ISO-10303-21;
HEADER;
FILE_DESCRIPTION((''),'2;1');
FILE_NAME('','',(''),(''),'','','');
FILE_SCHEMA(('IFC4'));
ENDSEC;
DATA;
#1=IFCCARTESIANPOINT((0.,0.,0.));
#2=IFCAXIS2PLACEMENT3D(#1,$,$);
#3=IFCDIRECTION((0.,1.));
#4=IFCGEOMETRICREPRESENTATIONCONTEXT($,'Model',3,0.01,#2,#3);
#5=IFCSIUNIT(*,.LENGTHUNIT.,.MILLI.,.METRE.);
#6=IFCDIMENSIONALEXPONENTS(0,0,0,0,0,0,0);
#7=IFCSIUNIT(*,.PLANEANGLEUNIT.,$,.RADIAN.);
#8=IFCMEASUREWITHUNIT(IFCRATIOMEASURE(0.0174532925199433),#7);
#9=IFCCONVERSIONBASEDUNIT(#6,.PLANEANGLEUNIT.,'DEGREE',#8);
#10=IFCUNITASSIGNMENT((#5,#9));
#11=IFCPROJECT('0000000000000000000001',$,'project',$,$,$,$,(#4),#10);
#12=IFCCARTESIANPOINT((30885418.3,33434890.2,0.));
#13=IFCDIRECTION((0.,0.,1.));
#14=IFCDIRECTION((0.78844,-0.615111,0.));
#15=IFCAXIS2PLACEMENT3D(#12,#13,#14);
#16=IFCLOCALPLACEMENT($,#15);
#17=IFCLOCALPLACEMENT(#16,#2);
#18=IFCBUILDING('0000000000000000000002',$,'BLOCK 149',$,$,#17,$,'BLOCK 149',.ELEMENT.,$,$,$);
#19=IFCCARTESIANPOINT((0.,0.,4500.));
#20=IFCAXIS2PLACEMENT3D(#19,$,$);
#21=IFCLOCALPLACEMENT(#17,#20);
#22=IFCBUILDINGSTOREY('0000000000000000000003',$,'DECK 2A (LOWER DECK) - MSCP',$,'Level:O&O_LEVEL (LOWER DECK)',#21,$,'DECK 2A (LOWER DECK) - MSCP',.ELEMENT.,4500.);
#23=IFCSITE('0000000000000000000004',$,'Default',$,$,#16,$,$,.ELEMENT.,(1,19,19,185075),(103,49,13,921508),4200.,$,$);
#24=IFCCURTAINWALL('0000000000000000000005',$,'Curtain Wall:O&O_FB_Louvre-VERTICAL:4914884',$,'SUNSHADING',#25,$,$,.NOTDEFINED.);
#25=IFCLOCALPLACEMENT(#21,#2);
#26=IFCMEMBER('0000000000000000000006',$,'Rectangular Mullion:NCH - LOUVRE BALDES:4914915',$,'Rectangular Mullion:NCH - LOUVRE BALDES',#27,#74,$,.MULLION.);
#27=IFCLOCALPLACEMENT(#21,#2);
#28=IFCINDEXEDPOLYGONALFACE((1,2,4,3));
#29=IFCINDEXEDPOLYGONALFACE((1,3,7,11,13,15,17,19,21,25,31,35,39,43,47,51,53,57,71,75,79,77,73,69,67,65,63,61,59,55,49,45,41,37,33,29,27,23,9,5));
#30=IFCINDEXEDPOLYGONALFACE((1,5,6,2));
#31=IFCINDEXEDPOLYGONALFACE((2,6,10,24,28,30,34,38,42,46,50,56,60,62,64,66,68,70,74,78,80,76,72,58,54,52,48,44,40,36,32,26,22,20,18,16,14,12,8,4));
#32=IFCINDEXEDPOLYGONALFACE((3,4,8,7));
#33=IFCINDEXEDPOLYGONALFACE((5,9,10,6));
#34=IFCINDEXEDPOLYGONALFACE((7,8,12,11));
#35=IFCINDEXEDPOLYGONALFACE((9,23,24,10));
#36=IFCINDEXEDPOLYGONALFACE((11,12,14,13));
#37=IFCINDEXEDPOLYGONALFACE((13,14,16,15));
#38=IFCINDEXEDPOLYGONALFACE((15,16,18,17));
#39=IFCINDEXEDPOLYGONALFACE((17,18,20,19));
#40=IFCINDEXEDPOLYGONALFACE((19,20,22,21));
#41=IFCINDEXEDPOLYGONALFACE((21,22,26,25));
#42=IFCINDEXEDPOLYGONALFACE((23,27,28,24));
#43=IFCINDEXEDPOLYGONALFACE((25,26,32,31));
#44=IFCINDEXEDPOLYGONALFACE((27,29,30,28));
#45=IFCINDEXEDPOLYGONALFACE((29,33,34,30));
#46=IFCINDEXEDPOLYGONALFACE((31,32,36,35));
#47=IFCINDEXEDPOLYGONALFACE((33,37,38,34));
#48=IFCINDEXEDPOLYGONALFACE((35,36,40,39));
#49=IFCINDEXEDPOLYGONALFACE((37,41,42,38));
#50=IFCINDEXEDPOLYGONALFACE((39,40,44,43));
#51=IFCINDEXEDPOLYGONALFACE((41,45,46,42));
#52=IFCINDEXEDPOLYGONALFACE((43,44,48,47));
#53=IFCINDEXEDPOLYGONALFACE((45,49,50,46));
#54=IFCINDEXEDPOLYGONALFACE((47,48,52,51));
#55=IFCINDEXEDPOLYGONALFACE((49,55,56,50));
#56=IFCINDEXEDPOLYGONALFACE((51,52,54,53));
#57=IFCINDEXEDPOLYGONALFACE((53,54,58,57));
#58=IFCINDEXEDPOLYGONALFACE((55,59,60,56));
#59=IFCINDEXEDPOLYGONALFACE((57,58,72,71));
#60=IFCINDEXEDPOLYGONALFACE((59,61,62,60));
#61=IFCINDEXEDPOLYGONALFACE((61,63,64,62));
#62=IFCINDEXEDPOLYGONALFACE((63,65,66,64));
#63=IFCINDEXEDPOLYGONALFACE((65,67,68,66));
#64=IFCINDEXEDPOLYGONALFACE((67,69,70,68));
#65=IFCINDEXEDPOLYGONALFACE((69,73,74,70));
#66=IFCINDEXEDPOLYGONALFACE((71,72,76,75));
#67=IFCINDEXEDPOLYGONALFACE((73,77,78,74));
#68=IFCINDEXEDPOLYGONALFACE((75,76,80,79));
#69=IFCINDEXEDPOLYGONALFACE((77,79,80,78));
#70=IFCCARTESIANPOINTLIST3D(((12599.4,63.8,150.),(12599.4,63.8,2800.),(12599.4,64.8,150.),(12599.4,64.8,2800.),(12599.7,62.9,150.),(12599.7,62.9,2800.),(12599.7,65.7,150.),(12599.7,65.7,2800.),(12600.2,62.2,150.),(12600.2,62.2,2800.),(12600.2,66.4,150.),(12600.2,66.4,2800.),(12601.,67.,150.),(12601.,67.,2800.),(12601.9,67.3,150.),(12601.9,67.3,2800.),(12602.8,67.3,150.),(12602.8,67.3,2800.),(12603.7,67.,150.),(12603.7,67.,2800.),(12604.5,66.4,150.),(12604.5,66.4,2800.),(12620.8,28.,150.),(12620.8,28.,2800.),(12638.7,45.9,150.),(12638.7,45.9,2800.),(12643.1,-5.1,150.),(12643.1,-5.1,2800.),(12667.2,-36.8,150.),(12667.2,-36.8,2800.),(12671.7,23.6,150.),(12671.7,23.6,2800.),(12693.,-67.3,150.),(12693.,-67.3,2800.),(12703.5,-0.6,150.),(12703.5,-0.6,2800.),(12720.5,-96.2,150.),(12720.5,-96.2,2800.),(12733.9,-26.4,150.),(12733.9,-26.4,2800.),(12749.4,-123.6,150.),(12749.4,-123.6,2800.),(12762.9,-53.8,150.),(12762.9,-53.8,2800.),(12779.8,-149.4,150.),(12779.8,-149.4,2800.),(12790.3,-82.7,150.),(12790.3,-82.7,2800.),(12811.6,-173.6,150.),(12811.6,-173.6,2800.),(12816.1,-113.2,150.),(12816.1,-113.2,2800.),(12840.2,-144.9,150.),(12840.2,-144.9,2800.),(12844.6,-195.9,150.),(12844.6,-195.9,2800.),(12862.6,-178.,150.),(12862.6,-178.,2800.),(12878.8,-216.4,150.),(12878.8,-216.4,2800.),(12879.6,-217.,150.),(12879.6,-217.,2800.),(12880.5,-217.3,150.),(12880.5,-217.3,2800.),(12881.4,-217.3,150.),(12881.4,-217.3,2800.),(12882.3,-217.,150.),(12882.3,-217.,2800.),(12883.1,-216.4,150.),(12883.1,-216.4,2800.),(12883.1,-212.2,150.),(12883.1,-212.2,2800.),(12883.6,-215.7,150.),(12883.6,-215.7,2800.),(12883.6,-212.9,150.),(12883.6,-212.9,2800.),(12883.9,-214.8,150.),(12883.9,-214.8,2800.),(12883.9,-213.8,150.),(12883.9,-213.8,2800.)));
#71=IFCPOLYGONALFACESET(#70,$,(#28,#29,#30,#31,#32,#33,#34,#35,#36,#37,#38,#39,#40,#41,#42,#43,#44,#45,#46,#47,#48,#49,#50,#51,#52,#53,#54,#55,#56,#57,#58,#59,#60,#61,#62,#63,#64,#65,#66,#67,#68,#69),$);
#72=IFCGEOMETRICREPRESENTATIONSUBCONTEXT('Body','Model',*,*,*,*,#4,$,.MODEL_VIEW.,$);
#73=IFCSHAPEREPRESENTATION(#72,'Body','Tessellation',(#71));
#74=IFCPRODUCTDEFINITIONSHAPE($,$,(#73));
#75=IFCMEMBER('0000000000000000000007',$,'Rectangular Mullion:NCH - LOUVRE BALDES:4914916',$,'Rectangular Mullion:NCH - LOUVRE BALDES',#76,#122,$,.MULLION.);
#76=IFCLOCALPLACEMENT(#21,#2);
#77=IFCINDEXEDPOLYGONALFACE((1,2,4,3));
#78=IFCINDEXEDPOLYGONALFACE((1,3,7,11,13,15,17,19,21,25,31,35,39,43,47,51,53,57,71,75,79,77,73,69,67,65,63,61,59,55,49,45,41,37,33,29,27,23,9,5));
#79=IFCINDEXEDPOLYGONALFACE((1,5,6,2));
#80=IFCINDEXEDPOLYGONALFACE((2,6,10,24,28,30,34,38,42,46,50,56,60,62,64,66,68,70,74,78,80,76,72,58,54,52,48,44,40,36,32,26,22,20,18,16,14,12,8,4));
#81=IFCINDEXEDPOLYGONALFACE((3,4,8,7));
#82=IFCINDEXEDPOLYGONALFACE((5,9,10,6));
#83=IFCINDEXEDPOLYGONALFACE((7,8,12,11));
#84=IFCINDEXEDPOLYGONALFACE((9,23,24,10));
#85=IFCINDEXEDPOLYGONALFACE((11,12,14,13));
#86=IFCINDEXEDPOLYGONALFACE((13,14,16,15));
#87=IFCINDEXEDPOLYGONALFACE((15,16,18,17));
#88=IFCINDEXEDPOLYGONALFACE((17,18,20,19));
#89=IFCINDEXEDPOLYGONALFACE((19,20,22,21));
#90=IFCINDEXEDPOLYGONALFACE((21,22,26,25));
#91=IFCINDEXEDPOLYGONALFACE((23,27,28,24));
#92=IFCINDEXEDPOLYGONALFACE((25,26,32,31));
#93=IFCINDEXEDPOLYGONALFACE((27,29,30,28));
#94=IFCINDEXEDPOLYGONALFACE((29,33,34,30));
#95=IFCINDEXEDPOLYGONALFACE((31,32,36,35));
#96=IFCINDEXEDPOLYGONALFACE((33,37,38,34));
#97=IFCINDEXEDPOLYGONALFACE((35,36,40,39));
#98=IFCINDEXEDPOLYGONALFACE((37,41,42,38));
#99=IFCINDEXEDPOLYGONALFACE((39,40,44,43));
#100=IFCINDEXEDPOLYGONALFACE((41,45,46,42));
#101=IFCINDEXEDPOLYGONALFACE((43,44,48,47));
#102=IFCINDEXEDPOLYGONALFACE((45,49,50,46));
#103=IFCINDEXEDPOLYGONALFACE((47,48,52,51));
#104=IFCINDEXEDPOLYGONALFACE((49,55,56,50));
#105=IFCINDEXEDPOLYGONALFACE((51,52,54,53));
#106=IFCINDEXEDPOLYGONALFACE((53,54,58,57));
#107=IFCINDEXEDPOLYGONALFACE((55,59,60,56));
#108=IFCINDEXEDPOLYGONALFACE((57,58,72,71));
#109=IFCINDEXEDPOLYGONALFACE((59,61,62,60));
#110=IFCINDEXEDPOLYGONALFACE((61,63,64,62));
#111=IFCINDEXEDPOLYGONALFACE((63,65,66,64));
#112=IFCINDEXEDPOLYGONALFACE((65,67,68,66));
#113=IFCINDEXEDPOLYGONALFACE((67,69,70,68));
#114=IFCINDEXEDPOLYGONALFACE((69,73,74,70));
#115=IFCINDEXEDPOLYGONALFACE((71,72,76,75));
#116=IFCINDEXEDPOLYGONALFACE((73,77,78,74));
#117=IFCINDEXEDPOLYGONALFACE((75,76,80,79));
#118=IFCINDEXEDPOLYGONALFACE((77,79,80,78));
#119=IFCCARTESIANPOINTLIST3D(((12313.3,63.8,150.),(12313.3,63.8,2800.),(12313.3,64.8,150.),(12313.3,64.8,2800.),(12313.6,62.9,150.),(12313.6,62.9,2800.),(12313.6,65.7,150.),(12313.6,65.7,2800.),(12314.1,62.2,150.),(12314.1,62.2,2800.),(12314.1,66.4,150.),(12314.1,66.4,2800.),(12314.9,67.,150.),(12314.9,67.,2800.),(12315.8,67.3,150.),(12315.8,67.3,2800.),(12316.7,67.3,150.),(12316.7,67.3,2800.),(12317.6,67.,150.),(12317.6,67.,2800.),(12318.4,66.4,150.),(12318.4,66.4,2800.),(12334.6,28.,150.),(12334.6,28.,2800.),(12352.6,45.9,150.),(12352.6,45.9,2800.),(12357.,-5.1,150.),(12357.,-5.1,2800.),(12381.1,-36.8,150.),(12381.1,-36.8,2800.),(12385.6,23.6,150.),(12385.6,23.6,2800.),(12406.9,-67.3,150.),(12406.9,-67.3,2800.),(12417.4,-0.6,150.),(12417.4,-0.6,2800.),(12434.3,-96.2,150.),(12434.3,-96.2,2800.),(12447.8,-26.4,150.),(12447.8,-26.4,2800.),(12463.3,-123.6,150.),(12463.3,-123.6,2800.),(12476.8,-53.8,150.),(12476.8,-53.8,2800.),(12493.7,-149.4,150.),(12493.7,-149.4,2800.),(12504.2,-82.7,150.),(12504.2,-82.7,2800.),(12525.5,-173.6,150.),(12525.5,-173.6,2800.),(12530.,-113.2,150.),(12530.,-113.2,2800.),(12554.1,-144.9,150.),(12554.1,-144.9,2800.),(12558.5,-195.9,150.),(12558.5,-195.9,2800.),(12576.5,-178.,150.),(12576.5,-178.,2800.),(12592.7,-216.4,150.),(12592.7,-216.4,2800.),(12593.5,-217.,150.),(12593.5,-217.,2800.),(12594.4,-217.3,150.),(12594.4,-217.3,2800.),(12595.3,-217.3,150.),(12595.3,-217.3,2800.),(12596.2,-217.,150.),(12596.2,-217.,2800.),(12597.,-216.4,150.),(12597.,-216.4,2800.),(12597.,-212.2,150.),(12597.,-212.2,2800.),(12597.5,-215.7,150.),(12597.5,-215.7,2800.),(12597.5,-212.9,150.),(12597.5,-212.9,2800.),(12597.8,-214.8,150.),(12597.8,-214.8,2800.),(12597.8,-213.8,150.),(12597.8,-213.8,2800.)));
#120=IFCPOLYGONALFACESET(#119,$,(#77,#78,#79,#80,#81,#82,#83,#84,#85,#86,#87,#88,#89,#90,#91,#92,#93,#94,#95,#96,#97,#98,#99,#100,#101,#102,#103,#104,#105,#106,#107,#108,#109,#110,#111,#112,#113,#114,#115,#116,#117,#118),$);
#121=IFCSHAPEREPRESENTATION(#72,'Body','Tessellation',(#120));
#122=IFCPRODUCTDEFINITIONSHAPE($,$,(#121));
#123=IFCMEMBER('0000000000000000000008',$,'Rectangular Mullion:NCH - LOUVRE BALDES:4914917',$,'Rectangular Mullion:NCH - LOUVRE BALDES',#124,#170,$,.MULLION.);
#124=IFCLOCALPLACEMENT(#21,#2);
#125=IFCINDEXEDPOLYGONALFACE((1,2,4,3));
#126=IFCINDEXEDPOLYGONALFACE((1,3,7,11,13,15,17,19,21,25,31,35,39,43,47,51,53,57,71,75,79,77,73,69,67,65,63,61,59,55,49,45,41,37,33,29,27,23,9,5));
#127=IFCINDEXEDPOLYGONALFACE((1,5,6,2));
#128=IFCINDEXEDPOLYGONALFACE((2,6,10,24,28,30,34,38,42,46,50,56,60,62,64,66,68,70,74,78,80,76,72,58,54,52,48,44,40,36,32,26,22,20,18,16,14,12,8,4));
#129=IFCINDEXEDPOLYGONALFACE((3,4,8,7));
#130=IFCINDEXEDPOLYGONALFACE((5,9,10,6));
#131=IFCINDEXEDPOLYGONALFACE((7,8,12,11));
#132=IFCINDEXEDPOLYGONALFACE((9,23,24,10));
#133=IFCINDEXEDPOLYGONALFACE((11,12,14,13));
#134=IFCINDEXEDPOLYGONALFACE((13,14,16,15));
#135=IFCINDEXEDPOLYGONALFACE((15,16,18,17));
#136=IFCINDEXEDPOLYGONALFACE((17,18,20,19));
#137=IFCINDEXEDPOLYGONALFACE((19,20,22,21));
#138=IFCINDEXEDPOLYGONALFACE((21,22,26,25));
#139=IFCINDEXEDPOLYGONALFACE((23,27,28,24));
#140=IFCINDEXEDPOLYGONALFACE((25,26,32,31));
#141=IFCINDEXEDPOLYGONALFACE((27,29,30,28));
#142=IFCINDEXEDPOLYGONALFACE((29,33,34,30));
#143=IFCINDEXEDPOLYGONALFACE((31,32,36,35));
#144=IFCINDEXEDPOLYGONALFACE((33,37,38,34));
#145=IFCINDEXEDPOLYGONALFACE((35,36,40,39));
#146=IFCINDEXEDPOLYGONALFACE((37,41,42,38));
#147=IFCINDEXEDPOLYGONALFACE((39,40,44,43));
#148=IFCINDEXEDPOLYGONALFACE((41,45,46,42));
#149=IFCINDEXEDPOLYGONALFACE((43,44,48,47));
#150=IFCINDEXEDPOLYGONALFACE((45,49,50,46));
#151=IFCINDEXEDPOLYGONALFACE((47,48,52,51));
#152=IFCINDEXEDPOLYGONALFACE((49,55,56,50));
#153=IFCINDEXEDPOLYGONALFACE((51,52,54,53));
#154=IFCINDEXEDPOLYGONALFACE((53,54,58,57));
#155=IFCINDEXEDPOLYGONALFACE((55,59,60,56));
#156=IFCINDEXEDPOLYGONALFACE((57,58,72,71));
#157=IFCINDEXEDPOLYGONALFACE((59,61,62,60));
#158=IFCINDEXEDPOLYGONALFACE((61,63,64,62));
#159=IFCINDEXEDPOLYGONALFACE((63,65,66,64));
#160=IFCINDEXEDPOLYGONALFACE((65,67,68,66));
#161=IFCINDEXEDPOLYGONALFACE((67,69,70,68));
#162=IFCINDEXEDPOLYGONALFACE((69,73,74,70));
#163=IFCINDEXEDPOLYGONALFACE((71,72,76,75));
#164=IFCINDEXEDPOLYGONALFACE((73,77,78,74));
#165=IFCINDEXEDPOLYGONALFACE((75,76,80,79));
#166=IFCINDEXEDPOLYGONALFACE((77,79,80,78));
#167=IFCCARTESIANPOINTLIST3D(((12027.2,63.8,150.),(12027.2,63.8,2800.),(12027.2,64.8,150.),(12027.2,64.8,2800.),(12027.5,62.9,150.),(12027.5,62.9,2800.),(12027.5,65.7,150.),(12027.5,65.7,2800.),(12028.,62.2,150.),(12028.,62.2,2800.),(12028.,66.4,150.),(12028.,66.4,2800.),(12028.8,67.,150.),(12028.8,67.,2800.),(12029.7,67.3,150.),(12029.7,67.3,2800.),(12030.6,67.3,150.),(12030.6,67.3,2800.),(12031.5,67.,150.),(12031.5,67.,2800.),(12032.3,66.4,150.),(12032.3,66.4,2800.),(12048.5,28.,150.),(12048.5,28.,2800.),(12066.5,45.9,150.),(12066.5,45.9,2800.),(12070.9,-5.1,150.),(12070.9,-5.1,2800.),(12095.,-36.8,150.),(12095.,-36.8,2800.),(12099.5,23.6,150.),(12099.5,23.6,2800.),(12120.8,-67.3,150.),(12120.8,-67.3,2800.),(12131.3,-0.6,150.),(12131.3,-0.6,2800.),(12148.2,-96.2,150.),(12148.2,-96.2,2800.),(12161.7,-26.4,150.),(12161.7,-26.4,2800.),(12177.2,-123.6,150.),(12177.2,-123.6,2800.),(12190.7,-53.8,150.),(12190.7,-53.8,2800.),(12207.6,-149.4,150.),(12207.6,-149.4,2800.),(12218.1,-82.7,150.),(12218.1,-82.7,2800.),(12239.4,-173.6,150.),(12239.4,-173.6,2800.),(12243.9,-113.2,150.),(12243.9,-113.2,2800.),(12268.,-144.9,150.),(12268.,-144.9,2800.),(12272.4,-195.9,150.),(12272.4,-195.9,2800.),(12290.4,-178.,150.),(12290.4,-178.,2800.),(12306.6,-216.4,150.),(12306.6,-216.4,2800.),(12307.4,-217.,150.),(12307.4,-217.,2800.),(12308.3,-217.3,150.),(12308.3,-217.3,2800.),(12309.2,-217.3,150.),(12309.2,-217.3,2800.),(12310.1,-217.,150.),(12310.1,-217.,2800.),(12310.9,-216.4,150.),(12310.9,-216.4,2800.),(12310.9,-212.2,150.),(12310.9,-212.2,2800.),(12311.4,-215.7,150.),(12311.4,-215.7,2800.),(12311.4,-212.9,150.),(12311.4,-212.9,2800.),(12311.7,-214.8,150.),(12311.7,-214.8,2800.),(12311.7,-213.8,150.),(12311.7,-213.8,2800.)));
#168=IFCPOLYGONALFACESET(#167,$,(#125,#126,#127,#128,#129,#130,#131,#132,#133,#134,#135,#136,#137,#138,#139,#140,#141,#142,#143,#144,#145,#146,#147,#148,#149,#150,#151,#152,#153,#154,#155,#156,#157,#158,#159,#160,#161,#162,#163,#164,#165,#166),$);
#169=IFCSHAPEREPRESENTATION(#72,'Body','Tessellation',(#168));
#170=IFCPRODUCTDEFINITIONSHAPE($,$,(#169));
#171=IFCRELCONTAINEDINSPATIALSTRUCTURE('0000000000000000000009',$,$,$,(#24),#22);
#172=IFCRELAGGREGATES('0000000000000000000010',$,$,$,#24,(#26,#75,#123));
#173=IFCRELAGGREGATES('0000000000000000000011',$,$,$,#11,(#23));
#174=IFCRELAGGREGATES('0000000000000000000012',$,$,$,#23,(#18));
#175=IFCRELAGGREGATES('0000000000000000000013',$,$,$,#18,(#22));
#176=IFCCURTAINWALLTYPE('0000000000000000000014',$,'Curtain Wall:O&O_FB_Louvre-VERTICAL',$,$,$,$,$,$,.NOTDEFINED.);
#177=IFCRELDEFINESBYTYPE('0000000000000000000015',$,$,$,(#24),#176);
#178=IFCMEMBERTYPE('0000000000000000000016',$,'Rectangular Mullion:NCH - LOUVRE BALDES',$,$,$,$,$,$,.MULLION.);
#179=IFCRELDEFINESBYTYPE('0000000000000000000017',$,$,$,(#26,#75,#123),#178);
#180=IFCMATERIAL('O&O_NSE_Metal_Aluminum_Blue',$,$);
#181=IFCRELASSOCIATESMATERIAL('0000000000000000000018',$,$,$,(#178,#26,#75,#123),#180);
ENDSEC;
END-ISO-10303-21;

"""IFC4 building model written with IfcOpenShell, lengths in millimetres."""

from ifc_helpers import new_model, entity, si_unit, converted_unit, direction, frame, origin, place, context, subcontext, project, spatial, indexed_curve, outline, extrude, source, transform, mapped, material, type_object, type_shapes, element, aggregate, save


model = new_model("IFC4")

# Units and contexts
model_context = context("Model", 3, precision=0.01, world=origin(), true_north=direction((0.0, 1.0)))
body_context = subcontext(model_context, "Body", "Model", "MODEL_VIEW")
ifc_project = project(units=[si_unit("LENGTHUNIT", "METRE", prefix="MILLI"), converted_unit("PLANEANGLEUNIT", "DEGREE", entity("IfcRatioMeasure", 0.0174532925199433), si_unit("PLANEANGLEUNIT", "RADIAN"), dimensions=[0, 0, 0, 0, 0, 0, 0])], contexts=[model_context])

# Site, building, storey
site_placement = place(None, frame((30885418.3, 33434890.2, 0.0), z_axis=(0.0, 0.0, 1.0), x_axis=(0.78844, -0.615111, 0.0)))
site = spatial("IfcSite", under=ifc_project, at=site_placement, Name="Default", CompositionType="ELEMENT", RefLatitude=(1, 19, 19, 185075), RefLongitude=(103, 49, 13, 921508), RefElevation=4200.0)
building_placement = place(site_placement, origin())
building = spatial("IfcBuilding", under=site, at=building_placement, Name="BLOCK 149", LongName="BLOCK 149", CompositionType="ELEMENT")
storey_placement = place(building_placement, frame((0.0, 0.0, 4500.0)))
storey = spatial("IfcBuildingStorey", under=building, at=storey_placement, Name="DECK 2A (LOWER DECK) - MSCP", ObjectType="Level:O&O_LEVEL (LOWER DECK)", LongName="DECK 2A (LOWER DECK) - MSCP", CompositionType="ELEMENT", Elevation=4500.0)

# Shared definitions
curtain_wall_type = type_object("IfcCurtainWallType", Name="Curtain Wall:O&O_FB_Louvre-VERTICAL", PredefinedType="NOTDEFINED")

# Curtain wall
curtain_wall_1_placement = place(storey_placement, frame((0.0, 0.0, -4500.0)))
curtain_wall_1 = element("IfcCurtainWall", 1, at=curtain_wall_1_placement, inside=storey, type_object=curtain_wall_type, Name="Curtain Wall:O&O_FB_Louvre-VERTICAL:4914884", ObjectType="SUNSHADING", PredefinedType="NOTDEFINED")

# Members
ifc_material_1 = material(Name="O&O_NSE_Metal_Aluminum_Blue")
member_type_1 = type_object("IfcMemberType", Name="Rectangular Mullion:NCH - LOUVRE BALDES", PredefinedType="MULLION", material=ifc_material_1)
shared_shape_1 = source(origin(), body_context, "Body", "SweptSolid", [
    extrude(outline(indexed_curve([(55.9, -188.9), (54.8, -149.1), (51.6, -109.3), (46.1, -69.8), (38.6, -30.6), (28.9, 8.1), (17.1, 46.2), (3.3, 83.6), (-12.6, 120.2), (-30.4, 155.9), (-50.1, 190.5), (-50.5, 191.4), (-51.1, 192.1), (-52.0, 192.5), (-52.9, 192.7), (-53.8, 192.6), (-54.7, 192.2), (-55.4, 191.6), (-55.8, 190.8), (-56.0, 189.9), (-55.9, 188.9), (-54.8, 149.1), (-51.6, 109.3), (-46.1, 69.8), (-38.6, 30.6), (-28.9, -8.1), (-17.1, -46.2), (-3.3, -83.6), (12.6, -120.2), (30.4, -155.9), (50.1, -190.5), (50.5, -191.4), (51.1, -192.1), (52.0, -192.5), (52.9, -192.7), (53.8, -192.6), (54.7, -192.2), (55.4, -191.6), (55.8, -190.8), (56.0, -189.9), (55.9, -188.9)], self_intersect=False)), frame((0.0, 0.0, -2650.0), z_axis=(0.0, 0.0, 1.0), x_axis=(0.490779, -0.871284, 0.0)), (0.0, 0.0, 1.0), 2650.0),
])
type_shapes(member_type_1, [shared_shape_1])
member_1_placement = place(storey_placement, frame((12741.7, -75.0, 150.0), z_axis=(0.0, 0.0, -1.0), x_axis=(-1.0, 0.0, 0.0)))
member_1 = element("IfcMember", 2, at=member_1_placement, type_object=member_type_1, material=ifc_material_1, Name="Rectangular Mullion:NCH - LOUVRE BALDES:4914915", ObjectType="Rectangular Mullion:NCH - LOUVRE BALDES", PredefinedType="MULLION", context=body_context, shape_type="MappedRepresentation", body=[
    mapped(shared_shape_1, transform((0.0, 0.0, 0.0), scale=1.0)),
])
member_2_placement = place(storey_placement, frame((12455.6, -75.0, 150.0), z_axis=(0.0, 0.0, -1.0), x_axis=(-1.0, 0.0, 0.0)))
member_2 = element("IfcMember", 3, at=member_2_placement, type_object=member_type_1, material=ifc_material_1, Name="Rectangular Mullion:NCH - LOUVRE BALDES:4914916", ObjectType="Rectangular Mullion:NCH - LOUVRE BALDES", PredefinedType="MULLION", context=body_context, shape_type="MappedRepresentation", body=[
    mapped(shared_shape_1, transform((0.0, 0.0, 0.0), scale=1.0)),
])
member_3_placement = place(storey_placement, frame((12169.4, -75.0, 150.0), z_axis=(0.0, 0.0, -1.0), x_axis=(-1.0, 0.0, 0.0)))
member_3 = element("IfcMember", 4, at=member_3_placement, type_object=member_type_1, material=ifc_material_1, Name="Rectangular Mullion:NCH - LOUVRE BALDES:4914917", ObjectType="Rectangular Mullion:NCH - LOUVRE BALDES", PredefinedType="MULLION", context=body_context, shape_type="MappedRepresentation", body=[
    mapped(shared_shape_1, transform((0.0, 0.0, 0.0), scale=1.0)),
])
aggregate(curtain_wall_1, [member_1, member_2, member_3])

save(model, "model.ifc")
